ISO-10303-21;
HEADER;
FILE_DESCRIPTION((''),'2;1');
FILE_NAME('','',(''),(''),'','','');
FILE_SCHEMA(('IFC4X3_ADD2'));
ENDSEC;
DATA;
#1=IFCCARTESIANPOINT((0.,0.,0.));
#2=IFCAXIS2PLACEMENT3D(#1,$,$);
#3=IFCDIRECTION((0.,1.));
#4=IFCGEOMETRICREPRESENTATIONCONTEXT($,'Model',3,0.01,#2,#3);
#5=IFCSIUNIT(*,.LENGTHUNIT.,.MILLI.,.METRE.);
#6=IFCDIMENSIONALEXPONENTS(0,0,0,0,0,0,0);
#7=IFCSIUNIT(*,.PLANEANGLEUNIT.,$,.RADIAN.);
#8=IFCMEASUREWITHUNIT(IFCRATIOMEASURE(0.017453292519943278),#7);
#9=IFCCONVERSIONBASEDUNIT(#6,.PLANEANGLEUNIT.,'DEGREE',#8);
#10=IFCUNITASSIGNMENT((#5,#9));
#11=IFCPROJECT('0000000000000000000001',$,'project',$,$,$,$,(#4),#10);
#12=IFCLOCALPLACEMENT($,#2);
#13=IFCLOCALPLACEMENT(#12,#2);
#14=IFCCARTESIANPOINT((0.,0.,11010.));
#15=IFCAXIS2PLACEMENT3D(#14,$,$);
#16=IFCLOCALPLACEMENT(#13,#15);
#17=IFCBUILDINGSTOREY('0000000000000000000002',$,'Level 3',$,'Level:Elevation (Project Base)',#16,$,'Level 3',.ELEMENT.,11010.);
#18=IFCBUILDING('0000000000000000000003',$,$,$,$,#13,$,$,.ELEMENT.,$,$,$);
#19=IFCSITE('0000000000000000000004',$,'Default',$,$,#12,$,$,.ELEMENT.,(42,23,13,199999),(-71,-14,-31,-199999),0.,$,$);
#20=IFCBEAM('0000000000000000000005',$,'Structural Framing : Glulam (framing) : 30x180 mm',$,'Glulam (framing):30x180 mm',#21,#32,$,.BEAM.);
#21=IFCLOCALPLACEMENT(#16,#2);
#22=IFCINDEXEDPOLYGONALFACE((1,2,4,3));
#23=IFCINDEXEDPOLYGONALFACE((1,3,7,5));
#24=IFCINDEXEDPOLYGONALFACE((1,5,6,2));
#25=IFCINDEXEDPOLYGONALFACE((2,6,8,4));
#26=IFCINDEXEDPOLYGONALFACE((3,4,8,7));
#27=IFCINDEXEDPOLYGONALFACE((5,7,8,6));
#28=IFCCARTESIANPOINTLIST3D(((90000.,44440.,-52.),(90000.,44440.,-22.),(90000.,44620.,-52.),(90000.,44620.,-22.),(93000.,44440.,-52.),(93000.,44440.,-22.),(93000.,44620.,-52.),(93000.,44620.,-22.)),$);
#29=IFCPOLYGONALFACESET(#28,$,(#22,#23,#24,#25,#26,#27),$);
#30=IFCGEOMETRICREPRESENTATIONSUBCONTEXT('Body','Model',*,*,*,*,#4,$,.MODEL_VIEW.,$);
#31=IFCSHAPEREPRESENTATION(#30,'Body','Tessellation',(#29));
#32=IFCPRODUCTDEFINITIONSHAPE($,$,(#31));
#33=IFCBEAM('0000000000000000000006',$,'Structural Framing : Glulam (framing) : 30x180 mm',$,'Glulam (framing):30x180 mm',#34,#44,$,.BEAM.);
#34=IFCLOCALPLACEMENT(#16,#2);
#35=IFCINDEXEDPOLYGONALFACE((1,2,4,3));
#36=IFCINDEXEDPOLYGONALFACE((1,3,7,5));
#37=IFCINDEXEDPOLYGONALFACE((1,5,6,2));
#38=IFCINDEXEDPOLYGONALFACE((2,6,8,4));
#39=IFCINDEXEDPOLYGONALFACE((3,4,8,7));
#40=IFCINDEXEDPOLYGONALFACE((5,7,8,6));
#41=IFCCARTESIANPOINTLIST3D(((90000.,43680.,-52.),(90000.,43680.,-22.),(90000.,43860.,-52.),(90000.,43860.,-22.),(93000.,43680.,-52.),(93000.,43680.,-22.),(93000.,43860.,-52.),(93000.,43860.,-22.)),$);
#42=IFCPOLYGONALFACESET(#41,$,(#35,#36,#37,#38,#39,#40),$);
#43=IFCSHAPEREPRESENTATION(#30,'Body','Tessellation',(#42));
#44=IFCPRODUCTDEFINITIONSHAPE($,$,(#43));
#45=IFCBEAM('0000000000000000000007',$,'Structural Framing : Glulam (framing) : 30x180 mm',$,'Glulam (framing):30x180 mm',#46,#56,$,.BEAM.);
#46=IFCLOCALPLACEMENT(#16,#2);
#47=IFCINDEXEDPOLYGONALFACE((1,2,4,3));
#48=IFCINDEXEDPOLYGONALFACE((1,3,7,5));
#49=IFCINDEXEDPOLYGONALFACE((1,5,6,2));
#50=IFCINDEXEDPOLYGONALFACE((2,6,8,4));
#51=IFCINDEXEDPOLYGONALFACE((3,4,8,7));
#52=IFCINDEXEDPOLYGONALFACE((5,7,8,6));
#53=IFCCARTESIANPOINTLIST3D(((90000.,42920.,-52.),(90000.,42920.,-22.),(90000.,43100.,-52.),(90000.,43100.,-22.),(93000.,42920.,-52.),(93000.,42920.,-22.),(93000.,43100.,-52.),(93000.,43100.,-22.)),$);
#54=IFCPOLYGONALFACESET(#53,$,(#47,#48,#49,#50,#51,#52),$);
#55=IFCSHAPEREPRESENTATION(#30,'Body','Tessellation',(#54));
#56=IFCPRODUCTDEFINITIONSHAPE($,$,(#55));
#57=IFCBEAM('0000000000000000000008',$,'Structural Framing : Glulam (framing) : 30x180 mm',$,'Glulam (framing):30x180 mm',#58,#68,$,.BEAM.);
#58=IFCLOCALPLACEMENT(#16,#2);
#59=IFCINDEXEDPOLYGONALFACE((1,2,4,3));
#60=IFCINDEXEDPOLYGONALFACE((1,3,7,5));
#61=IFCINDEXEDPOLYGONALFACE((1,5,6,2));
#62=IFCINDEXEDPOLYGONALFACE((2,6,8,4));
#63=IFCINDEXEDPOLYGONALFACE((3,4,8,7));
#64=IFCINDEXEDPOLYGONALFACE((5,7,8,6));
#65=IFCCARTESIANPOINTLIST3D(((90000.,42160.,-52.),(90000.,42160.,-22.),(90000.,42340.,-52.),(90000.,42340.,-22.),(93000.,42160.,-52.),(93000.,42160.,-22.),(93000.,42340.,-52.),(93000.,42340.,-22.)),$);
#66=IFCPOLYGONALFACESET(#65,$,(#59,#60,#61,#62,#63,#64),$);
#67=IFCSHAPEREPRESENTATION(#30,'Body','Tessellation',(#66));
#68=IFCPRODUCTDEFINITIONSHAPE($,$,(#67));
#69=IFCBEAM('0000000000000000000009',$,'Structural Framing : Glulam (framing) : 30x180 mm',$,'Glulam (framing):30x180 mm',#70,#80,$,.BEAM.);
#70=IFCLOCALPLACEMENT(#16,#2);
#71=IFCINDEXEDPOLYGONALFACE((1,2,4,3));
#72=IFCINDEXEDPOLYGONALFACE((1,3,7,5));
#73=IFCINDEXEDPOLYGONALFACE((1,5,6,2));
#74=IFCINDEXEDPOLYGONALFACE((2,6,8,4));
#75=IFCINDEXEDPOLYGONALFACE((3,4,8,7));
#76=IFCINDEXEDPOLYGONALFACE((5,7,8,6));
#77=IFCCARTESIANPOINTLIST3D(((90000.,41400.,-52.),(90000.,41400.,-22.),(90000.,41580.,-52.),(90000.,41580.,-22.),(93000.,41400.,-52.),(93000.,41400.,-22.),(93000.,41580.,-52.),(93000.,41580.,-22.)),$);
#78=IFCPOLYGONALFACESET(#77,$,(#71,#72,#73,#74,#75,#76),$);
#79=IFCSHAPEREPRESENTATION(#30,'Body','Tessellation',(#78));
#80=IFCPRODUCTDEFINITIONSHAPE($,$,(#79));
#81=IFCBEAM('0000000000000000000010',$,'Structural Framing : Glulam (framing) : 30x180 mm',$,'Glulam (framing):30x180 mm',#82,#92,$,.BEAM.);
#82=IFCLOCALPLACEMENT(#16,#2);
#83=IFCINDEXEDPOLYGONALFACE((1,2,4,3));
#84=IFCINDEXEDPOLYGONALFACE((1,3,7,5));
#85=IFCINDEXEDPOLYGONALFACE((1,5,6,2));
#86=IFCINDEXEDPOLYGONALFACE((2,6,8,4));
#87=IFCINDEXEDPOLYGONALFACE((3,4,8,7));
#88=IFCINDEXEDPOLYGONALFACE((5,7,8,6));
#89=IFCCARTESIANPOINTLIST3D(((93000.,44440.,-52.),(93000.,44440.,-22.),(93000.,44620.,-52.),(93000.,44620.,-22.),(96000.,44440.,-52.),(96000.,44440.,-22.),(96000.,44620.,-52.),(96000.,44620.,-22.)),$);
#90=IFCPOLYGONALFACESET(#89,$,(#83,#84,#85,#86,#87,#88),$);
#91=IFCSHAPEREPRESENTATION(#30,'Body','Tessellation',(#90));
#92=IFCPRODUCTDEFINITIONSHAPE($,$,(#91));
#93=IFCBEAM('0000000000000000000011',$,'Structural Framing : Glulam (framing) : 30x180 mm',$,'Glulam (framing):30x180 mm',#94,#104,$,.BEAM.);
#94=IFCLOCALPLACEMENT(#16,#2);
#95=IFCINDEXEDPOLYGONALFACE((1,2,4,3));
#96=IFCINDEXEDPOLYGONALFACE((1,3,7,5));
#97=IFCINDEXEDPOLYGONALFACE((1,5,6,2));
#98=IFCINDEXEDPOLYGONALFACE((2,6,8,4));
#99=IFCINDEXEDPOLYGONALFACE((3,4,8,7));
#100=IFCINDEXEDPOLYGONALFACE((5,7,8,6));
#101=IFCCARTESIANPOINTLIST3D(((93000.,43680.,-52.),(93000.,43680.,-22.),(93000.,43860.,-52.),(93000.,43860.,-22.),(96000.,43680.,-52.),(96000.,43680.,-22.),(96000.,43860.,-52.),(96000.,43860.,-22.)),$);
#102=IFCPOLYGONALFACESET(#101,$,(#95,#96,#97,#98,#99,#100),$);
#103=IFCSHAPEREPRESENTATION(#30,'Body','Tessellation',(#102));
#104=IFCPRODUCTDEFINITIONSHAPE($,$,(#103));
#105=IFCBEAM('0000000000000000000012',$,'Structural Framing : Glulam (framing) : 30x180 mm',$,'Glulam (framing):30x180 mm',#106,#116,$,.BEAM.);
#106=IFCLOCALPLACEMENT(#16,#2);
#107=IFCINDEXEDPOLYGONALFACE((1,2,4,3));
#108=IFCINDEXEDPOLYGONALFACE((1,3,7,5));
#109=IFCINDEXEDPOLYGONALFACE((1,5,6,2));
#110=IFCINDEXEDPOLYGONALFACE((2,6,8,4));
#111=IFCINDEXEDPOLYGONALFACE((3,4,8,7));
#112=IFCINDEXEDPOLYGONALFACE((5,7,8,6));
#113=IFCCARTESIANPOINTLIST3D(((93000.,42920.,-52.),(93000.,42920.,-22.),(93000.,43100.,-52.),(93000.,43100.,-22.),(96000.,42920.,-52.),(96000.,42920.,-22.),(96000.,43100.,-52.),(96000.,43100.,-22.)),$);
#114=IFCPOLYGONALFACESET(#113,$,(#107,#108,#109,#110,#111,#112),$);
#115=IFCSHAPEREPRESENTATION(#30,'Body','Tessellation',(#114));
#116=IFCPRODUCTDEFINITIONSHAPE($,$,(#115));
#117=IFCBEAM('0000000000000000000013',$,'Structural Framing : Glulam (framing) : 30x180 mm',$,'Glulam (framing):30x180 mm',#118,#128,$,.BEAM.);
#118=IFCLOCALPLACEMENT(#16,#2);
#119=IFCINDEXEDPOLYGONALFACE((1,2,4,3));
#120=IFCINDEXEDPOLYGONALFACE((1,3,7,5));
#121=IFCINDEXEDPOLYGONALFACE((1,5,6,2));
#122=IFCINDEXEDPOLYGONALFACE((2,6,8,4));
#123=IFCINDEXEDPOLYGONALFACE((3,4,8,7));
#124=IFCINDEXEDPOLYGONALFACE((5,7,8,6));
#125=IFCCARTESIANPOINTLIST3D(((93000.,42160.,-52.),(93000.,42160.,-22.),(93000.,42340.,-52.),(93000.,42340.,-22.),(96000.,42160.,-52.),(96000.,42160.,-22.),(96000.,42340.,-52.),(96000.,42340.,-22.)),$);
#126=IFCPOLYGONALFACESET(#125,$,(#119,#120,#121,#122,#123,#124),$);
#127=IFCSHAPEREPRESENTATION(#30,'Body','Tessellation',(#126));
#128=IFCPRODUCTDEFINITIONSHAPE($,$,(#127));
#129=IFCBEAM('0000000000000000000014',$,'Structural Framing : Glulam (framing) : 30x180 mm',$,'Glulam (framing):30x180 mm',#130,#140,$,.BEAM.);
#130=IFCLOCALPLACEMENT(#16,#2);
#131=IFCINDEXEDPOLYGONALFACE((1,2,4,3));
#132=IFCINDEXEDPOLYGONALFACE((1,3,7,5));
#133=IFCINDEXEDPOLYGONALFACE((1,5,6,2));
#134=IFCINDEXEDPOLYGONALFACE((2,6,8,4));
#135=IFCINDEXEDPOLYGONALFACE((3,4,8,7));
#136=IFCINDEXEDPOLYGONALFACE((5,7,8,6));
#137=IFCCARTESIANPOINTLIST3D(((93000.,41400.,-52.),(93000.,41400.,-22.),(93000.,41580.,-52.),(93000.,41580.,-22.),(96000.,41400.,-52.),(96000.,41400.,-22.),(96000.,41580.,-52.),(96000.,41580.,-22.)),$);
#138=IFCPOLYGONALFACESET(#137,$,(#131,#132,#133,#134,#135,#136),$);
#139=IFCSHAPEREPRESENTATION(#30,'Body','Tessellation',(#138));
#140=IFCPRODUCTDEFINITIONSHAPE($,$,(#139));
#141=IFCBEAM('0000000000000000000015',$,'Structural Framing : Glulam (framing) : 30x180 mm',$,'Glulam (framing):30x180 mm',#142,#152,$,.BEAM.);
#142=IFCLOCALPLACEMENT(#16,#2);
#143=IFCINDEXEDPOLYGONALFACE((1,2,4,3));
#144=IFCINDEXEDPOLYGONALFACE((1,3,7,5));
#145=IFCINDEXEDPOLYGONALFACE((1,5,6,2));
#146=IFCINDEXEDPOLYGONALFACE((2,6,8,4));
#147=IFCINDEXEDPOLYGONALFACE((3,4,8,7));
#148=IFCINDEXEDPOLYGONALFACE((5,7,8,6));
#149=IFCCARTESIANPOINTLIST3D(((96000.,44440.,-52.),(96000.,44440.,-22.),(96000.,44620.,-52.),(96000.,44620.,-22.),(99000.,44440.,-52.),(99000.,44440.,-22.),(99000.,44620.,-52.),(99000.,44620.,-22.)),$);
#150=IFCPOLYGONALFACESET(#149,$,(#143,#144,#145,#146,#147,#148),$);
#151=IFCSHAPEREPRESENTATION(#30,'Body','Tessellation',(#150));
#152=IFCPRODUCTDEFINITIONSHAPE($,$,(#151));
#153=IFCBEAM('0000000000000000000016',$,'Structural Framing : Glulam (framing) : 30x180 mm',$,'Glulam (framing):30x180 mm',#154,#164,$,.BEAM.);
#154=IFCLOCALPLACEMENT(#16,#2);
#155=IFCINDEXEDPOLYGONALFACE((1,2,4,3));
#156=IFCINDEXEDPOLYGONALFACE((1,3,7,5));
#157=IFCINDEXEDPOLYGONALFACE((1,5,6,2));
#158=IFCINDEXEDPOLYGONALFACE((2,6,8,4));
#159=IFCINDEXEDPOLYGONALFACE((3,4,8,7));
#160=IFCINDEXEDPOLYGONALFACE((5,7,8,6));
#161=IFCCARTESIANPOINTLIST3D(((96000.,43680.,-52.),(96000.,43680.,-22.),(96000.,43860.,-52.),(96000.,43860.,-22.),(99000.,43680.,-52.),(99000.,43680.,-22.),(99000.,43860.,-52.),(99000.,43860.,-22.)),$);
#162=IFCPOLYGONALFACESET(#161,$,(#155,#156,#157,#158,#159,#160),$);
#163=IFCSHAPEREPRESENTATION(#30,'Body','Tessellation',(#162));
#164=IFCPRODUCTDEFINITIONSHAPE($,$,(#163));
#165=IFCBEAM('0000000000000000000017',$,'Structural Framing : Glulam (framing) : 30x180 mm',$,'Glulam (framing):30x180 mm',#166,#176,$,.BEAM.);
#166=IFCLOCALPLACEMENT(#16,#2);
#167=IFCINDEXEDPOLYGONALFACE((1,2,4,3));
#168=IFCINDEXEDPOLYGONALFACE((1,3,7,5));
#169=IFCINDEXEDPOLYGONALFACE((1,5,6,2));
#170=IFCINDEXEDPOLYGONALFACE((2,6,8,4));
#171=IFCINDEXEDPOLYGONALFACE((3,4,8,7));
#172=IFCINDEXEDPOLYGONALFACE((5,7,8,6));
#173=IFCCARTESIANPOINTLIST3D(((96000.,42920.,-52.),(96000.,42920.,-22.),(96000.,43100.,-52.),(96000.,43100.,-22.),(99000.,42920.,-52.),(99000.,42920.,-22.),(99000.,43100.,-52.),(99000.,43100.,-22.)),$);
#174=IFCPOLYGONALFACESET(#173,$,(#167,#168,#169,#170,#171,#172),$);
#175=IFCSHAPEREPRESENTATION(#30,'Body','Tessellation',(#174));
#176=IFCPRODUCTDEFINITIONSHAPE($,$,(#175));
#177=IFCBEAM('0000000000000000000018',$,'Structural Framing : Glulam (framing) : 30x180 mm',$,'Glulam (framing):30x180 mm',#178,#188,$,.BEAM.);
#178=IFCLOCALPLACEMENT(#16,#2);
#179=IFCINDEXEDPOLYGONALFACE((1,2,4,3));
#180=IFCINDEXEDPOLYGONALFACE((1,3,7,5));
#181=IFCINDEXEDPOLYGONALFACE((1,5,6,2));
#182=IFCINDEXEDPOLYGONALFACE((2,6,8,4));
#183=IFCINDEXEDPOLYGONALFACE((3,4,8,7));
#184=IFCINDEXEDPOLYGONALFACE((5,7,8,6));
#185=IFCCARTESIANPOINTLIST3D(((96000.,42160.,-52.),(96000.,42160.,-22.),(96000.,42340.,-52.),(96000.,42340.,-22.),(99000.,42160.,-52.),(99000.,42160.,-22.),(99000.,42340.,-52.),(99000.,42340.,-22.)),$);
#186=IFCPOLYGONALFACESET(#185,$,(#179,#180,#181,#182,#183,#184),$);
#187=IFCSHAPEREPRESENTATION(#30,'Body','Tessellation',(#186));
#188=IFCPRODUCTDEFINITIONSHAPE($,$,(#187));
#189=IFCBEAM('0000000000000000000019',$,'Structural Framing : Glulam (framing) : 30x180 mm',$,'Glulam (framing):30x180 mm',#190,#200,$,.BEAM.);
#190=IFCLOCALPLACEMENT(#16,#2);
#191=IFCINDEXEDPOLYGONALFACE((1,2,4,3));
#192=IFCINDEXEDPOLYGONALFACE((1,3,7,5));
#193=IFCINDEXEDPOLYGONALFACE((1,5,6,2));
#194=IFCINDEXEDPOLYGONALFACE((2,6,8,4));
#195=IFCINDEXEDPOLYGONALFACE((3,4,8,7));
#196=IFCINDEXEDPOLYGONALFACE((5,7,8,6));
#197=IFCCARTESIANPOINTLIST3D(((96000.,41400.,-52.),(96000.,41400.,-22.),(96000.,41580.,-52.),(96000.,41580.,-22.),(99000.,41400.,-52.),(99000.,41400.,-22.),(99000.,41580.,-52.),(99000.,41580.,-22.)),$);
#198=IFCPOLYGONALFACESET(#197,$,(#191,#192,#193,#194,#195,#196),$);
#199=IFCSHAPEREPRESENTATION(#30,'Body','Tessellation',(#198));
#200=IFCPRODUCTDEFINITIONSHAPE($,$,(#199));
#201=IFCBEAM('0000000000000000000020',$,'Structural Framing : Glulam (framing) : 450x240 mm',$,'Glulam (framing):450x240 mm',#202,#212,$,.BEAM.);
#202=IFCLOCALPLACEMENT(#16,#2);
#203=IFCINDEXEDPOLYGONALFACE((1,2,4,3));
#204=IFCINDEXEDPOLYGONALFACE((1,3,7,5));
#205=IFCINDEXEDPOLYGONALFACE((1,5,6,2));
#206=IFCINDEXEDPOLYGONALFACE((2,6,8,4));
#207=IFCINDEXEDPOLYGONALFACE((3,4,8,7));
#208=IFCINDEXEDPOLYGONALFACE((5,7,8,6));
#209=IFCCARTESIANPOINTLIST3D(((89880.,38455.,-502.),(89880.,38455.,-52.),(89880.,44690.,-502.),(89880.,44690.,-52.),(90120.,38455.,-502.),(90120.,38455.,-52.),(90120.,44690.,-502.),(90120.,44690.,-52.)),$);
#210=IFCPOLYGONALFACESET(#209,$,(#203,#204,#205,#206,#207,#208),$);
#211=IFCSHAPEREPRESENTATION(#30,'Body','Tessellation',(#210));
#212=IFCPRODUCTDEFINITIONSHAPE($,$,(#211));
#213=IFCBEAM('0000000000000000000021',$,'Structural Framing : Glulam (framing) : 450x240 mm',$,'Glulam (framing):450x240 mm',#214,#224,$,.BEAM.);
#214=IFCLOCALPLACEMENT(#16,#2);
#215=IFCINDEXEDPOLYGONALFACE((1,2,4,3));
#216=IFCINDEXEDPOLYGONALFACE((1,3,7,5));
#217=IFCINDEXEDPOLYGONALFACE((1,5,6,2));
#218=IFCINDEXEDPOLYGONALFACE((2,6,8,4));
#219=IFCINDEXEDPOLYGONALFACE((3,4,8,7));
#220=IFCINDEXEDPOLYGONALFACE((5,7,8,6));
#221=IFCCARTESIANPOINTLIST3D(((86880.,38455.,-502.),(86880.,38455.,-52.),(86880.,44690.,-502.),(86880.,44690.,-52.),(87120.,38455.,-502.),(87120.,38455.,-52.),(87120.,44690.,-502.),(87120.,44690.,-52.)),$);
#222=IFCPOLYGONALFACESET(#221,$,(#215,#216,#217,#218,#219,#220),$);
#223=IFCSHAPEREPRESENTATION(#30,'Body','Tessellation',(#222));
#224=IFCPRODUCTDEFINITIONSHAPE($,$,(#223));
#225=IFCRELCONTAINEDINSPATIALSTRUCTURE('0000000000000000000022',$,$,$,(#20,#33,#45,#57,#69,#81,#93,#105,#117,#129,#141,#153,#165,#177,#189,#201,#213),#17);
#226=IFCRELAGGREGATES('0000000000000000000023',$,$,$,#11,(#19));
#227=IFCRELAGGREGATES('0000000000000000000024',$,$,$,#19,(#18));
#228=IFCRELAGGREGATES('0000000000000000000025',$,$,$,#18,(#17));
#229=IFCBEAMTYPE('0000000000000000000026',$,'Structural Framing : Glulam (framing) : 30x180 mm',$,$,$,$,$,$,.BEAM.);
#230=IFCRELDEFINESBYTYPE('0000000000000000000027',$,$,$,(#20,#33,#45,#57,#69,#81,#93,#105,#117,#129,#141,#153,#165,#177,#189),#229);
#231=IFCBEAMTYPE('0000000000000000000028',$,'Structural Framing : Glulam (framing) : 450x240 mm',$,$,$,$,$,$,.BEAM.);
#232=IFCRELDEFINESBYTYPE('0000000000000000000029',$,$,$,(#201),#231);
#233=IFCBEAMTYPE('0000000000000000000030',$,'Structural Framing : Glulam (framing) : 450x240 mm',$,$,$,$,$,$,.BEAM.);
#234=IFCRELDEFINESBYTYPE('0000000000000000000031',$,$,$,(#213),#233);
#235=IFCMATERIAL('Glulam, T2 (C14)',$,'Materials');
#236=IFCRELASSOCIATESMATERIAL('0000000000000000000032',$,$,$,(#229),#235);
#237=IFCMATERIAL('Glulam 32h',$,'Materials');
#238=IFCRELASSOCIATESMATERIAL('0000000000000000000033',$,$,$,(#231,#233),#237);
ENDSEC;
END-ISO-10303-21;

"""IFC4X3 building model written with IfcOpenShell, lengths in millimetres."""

from ifc_helpers import new_model, entity, si_unit, converted_unit, direction, frame, origin, origin_2d_with_axis, place, context, subcontext, project, spatial, rectangle, extrude, source, transform, mapped, material, material_profile, profile_set, type_object, type_shapes, element, save


model = new_model("IFC4X3")

# Units and contexts
model_context = context("Model", 3, precision=0.01, world=origin(), true_north=direction((0.0, 1.0)))
body_context = subcontext(model_context, "Body", "Model", "MODEL_VIEW")
ifc_project = project(units=[si_unit("LENGTHUNIT", "METRE", prefix="MILLI"), converted_unit("PLANEANGLEUNIT", "DEGREE", entity("IfcRatioMeasure", 0.017453292519943278), si_unit("PLANEANGLEUNIT", "RADIAN"), dimensions=[0, 0, 0, 0, 0, 0, 0])], contexts=[model_context])

# Site, building, storey
site_placement = place(None, origin())
site = spatial("IfcSite", under=ifc_project, at=site_placement, Name="Default", CompositionType="ELEMENT", RefLatitude=(42, 23, 13, 199999), RefLongitude=(-71, -14, -31, -199999), RefElevation=0.0)
building_placement = place(site_placement, origin())
building = spatial("IfcBuilding", under=site, at=building_placement, CompositionType="ELEMENT")
storey_placement = place(building_placement, frame((0.0, 0.0, 11010.0)))
storey = spatial("IfcBuildingStorey", under=building, at=storey_placement, Name="Level 3", ObjectType="Level:Elevation (Project Base)", LongName="Level 3", CompositionType="ELEMENT", Elevation=11010.0)

# Beams
ifc_material_1 = material(Name="Glulam, T2 (C14)", Category="Materials")
ifc_material_profile_1 = material_profile(ifc_material_1, rectangle(XDim=30.0, YDim=180.0, at=origin_2d_with_axis()), Name="30x180 mm")
ifc_profile_set_1 = profile_set([ifc_material_profile_1], Name="30x180 mm")
beam_type_1 = type_object("IfcBeamType", Name="Structural Framing : Glulam (framing) : 30x180 mm", PredefinedType="BEAM", material=ifc_profile_set_1)
shared_shape_1 = source(origin(), body_context, "Body", "SweptSolid", [
    extrude(rectangle(XDim=30.0, YDim=180.0, at=origin_2d_with_axis()), frame((500.0, 0.0, 0.0), z_axis=(1.0, 0.0, 0.0), x_axis=(0.0, 0.0, -1.0)), (0.0, 0.0, 1.0), 3000.0),
])
type_shapes(beam_type_1, [shared_shape_1])
for number, where, name in (
    (1, (89500.0, 44530.0, -37.0), "Structural Framing : Glulam (framing) : 30x180 mm"),
    (2, (89500.0, 43770.0, -37.0), "Structural Framing : Glulam (framing) : 30x180 mm"),
    (3, (89500.0, 43010.0, -37.0), "Structural Framing : Glulam (framing) : 30x180 mm"),
    (4, (89500.0, 42250.0, -37.0), "Structural Framing : Glulam (framing) : 30x180 mm"),
    (5, (89500.0, 41490.0, -37.0), "Structural Framing : Glulam (framing) : 30x180 mm"),
    (6, (92500.0, 44530.0, -37.0), "Structural Framing : Glulam (framing) : 30x180 mm"),
    (7, (92500.0, 43770.0, -37.0), "Structural Framing : Glulam (framing) : 30x180 mm"),
    (8, (92500.0, 43010.0, -37.0), "Structural Framing : Glulam (framing) : 30x180 mm"),
    (9, (92500.0, 42250.0, -37.0), "Structural Framing : Glulam (framing) : 30x180 mm"),
    (10, (92500.0, 41490.0, -37.0), "Structural Framing : Glulam (framing) : 30x180 mm"),
    (11, (95500.0, 44530.0, -37.0), "Structural Framing : Glulam (framing) : 30x180 mm"),
    (12, (95500.0, 43770.0, -37.0), "Structural Framing : Glulam (framing) : 30x180 mm"),
    (13, (95500.0, 43010.0, -37.0), "Structural Framing : Glulam (framing) : 30x180 mm"),
    (14, (95500.0, 42250.0, -37.0), "Structural Framing : Glulam (framing) : 30x180 mm"),
    (15, (95500.0, 41490.0, -37.0), "Structural Framing : Glulam (framing) : 30x180 mm"),
):
    element("IfcBeam", number, at=place(storey_placement, frame(where)), inside=storey, type_object=beam_type_1, Name=name, ObjectType="Glulam (framing):30x180 mm", PredefinedType="BEAM", context=body_context, shape_type="MappedRepresentation", body=[
        mapped(shared_shape_1, transform((0.0, 0.0, 0.0), scale=1.0)),
    ])
ifc_material_2 = material(Name="Glulam 32h", Category="Materials")
ifc_material_profile_2 = material_profile(ifc_material_2, rectangle(XDim=450.0, YDim=240.0, at=origin_2d_with_axis()), Name="450x240 mm")
ifc_profile_set_2 = profile_set([ifc_material_profile_2], Name="450x240 mm")
beam_type_2 = type_object("IfcBeamType", Name="Structural Framing : Glulam (framing) : 450x240 mm", PredefinedType="BEAM", material=ifc_profile_set_2)
shared_shape_2 = source(origin(), body_context, "Body", "SweptSolid", [
    extrude(rectangle(XDim=450.0, YDim=240.0, at=origin_2d_with_axis()), frame((-2890.0, 0.0, 0.0), z_axis=(1.0, 0.0, 0.0), x_axis=(0.0, 0.0, -1.0)), (0.0, 0.0, 1.0), 6235.0),
])
type_shapes(beam_type_2, [shared_shape_2])
beam_1_placement = place(storey_placement, frame((90000.0, 41800.0, -277.0), z_axis=(0.0, 0.0, 1.0), x_axis=(0.0, -1.0, 0.0)))
element("IfcBeam", 16, at=beam_1_placement, inside=storey, type_object=beam_type_2, Name="Structural Framing : Glulam (framing) : 450x240 mm", ObjectType="Glulam (framing):450x240 mm", PredefinedType="BEAM", context=body_context, shape_type="MappedRepresentation", body=[
    mapped(shared_shape_2, transform((0.0, 0.0, 0.0), scale=1.0)),
])
beam_type_3 = type_object("IfcBeamType", Name="Structural Framing : Glulam (framing) : 450x240 mm", PredefinedType="BEAM", material=ifc_profile_set_2)
shared_shape_3 = source(origin(), body_context, "Body", "SweptSolid", [
    extrude(rectangle(XDim=450.0, YDim=240.0, at=origin_2d_with_axis()), frame((-3256.2, 0.0, 0.0), z_axis=(1.0, 0.0, 0.0), x_axis=(0.0, 0.0, -1.0)), (0.0, 0.0, 1.0), 6235.0),
])
type_shapes(beam_type_3, [shared_shape_3])
beam_2_placement = place(storey_placement, frame((87000.0, 41433.7, -277.0), z_axis=(0.0, 0.0, 1.0), x_axis=(0.0, -1.0, 0.0)))
element("IfcBeam", 17, at=beam_2_placement, inside=storey, type_object=beam_type_3, Name="Structural Framing : Glulam (framing) : 450x240 mm", ObjectType="Glulam (framing):450x240 mm", PredefinedType="BEAM", context=body_context, shape_type="MappedRepresentation", body=[
    mapped(shared_shape_3, transform((0.0, 0.0, 0.0), scale=1.0)),
])

save(model, "model.ifc")
